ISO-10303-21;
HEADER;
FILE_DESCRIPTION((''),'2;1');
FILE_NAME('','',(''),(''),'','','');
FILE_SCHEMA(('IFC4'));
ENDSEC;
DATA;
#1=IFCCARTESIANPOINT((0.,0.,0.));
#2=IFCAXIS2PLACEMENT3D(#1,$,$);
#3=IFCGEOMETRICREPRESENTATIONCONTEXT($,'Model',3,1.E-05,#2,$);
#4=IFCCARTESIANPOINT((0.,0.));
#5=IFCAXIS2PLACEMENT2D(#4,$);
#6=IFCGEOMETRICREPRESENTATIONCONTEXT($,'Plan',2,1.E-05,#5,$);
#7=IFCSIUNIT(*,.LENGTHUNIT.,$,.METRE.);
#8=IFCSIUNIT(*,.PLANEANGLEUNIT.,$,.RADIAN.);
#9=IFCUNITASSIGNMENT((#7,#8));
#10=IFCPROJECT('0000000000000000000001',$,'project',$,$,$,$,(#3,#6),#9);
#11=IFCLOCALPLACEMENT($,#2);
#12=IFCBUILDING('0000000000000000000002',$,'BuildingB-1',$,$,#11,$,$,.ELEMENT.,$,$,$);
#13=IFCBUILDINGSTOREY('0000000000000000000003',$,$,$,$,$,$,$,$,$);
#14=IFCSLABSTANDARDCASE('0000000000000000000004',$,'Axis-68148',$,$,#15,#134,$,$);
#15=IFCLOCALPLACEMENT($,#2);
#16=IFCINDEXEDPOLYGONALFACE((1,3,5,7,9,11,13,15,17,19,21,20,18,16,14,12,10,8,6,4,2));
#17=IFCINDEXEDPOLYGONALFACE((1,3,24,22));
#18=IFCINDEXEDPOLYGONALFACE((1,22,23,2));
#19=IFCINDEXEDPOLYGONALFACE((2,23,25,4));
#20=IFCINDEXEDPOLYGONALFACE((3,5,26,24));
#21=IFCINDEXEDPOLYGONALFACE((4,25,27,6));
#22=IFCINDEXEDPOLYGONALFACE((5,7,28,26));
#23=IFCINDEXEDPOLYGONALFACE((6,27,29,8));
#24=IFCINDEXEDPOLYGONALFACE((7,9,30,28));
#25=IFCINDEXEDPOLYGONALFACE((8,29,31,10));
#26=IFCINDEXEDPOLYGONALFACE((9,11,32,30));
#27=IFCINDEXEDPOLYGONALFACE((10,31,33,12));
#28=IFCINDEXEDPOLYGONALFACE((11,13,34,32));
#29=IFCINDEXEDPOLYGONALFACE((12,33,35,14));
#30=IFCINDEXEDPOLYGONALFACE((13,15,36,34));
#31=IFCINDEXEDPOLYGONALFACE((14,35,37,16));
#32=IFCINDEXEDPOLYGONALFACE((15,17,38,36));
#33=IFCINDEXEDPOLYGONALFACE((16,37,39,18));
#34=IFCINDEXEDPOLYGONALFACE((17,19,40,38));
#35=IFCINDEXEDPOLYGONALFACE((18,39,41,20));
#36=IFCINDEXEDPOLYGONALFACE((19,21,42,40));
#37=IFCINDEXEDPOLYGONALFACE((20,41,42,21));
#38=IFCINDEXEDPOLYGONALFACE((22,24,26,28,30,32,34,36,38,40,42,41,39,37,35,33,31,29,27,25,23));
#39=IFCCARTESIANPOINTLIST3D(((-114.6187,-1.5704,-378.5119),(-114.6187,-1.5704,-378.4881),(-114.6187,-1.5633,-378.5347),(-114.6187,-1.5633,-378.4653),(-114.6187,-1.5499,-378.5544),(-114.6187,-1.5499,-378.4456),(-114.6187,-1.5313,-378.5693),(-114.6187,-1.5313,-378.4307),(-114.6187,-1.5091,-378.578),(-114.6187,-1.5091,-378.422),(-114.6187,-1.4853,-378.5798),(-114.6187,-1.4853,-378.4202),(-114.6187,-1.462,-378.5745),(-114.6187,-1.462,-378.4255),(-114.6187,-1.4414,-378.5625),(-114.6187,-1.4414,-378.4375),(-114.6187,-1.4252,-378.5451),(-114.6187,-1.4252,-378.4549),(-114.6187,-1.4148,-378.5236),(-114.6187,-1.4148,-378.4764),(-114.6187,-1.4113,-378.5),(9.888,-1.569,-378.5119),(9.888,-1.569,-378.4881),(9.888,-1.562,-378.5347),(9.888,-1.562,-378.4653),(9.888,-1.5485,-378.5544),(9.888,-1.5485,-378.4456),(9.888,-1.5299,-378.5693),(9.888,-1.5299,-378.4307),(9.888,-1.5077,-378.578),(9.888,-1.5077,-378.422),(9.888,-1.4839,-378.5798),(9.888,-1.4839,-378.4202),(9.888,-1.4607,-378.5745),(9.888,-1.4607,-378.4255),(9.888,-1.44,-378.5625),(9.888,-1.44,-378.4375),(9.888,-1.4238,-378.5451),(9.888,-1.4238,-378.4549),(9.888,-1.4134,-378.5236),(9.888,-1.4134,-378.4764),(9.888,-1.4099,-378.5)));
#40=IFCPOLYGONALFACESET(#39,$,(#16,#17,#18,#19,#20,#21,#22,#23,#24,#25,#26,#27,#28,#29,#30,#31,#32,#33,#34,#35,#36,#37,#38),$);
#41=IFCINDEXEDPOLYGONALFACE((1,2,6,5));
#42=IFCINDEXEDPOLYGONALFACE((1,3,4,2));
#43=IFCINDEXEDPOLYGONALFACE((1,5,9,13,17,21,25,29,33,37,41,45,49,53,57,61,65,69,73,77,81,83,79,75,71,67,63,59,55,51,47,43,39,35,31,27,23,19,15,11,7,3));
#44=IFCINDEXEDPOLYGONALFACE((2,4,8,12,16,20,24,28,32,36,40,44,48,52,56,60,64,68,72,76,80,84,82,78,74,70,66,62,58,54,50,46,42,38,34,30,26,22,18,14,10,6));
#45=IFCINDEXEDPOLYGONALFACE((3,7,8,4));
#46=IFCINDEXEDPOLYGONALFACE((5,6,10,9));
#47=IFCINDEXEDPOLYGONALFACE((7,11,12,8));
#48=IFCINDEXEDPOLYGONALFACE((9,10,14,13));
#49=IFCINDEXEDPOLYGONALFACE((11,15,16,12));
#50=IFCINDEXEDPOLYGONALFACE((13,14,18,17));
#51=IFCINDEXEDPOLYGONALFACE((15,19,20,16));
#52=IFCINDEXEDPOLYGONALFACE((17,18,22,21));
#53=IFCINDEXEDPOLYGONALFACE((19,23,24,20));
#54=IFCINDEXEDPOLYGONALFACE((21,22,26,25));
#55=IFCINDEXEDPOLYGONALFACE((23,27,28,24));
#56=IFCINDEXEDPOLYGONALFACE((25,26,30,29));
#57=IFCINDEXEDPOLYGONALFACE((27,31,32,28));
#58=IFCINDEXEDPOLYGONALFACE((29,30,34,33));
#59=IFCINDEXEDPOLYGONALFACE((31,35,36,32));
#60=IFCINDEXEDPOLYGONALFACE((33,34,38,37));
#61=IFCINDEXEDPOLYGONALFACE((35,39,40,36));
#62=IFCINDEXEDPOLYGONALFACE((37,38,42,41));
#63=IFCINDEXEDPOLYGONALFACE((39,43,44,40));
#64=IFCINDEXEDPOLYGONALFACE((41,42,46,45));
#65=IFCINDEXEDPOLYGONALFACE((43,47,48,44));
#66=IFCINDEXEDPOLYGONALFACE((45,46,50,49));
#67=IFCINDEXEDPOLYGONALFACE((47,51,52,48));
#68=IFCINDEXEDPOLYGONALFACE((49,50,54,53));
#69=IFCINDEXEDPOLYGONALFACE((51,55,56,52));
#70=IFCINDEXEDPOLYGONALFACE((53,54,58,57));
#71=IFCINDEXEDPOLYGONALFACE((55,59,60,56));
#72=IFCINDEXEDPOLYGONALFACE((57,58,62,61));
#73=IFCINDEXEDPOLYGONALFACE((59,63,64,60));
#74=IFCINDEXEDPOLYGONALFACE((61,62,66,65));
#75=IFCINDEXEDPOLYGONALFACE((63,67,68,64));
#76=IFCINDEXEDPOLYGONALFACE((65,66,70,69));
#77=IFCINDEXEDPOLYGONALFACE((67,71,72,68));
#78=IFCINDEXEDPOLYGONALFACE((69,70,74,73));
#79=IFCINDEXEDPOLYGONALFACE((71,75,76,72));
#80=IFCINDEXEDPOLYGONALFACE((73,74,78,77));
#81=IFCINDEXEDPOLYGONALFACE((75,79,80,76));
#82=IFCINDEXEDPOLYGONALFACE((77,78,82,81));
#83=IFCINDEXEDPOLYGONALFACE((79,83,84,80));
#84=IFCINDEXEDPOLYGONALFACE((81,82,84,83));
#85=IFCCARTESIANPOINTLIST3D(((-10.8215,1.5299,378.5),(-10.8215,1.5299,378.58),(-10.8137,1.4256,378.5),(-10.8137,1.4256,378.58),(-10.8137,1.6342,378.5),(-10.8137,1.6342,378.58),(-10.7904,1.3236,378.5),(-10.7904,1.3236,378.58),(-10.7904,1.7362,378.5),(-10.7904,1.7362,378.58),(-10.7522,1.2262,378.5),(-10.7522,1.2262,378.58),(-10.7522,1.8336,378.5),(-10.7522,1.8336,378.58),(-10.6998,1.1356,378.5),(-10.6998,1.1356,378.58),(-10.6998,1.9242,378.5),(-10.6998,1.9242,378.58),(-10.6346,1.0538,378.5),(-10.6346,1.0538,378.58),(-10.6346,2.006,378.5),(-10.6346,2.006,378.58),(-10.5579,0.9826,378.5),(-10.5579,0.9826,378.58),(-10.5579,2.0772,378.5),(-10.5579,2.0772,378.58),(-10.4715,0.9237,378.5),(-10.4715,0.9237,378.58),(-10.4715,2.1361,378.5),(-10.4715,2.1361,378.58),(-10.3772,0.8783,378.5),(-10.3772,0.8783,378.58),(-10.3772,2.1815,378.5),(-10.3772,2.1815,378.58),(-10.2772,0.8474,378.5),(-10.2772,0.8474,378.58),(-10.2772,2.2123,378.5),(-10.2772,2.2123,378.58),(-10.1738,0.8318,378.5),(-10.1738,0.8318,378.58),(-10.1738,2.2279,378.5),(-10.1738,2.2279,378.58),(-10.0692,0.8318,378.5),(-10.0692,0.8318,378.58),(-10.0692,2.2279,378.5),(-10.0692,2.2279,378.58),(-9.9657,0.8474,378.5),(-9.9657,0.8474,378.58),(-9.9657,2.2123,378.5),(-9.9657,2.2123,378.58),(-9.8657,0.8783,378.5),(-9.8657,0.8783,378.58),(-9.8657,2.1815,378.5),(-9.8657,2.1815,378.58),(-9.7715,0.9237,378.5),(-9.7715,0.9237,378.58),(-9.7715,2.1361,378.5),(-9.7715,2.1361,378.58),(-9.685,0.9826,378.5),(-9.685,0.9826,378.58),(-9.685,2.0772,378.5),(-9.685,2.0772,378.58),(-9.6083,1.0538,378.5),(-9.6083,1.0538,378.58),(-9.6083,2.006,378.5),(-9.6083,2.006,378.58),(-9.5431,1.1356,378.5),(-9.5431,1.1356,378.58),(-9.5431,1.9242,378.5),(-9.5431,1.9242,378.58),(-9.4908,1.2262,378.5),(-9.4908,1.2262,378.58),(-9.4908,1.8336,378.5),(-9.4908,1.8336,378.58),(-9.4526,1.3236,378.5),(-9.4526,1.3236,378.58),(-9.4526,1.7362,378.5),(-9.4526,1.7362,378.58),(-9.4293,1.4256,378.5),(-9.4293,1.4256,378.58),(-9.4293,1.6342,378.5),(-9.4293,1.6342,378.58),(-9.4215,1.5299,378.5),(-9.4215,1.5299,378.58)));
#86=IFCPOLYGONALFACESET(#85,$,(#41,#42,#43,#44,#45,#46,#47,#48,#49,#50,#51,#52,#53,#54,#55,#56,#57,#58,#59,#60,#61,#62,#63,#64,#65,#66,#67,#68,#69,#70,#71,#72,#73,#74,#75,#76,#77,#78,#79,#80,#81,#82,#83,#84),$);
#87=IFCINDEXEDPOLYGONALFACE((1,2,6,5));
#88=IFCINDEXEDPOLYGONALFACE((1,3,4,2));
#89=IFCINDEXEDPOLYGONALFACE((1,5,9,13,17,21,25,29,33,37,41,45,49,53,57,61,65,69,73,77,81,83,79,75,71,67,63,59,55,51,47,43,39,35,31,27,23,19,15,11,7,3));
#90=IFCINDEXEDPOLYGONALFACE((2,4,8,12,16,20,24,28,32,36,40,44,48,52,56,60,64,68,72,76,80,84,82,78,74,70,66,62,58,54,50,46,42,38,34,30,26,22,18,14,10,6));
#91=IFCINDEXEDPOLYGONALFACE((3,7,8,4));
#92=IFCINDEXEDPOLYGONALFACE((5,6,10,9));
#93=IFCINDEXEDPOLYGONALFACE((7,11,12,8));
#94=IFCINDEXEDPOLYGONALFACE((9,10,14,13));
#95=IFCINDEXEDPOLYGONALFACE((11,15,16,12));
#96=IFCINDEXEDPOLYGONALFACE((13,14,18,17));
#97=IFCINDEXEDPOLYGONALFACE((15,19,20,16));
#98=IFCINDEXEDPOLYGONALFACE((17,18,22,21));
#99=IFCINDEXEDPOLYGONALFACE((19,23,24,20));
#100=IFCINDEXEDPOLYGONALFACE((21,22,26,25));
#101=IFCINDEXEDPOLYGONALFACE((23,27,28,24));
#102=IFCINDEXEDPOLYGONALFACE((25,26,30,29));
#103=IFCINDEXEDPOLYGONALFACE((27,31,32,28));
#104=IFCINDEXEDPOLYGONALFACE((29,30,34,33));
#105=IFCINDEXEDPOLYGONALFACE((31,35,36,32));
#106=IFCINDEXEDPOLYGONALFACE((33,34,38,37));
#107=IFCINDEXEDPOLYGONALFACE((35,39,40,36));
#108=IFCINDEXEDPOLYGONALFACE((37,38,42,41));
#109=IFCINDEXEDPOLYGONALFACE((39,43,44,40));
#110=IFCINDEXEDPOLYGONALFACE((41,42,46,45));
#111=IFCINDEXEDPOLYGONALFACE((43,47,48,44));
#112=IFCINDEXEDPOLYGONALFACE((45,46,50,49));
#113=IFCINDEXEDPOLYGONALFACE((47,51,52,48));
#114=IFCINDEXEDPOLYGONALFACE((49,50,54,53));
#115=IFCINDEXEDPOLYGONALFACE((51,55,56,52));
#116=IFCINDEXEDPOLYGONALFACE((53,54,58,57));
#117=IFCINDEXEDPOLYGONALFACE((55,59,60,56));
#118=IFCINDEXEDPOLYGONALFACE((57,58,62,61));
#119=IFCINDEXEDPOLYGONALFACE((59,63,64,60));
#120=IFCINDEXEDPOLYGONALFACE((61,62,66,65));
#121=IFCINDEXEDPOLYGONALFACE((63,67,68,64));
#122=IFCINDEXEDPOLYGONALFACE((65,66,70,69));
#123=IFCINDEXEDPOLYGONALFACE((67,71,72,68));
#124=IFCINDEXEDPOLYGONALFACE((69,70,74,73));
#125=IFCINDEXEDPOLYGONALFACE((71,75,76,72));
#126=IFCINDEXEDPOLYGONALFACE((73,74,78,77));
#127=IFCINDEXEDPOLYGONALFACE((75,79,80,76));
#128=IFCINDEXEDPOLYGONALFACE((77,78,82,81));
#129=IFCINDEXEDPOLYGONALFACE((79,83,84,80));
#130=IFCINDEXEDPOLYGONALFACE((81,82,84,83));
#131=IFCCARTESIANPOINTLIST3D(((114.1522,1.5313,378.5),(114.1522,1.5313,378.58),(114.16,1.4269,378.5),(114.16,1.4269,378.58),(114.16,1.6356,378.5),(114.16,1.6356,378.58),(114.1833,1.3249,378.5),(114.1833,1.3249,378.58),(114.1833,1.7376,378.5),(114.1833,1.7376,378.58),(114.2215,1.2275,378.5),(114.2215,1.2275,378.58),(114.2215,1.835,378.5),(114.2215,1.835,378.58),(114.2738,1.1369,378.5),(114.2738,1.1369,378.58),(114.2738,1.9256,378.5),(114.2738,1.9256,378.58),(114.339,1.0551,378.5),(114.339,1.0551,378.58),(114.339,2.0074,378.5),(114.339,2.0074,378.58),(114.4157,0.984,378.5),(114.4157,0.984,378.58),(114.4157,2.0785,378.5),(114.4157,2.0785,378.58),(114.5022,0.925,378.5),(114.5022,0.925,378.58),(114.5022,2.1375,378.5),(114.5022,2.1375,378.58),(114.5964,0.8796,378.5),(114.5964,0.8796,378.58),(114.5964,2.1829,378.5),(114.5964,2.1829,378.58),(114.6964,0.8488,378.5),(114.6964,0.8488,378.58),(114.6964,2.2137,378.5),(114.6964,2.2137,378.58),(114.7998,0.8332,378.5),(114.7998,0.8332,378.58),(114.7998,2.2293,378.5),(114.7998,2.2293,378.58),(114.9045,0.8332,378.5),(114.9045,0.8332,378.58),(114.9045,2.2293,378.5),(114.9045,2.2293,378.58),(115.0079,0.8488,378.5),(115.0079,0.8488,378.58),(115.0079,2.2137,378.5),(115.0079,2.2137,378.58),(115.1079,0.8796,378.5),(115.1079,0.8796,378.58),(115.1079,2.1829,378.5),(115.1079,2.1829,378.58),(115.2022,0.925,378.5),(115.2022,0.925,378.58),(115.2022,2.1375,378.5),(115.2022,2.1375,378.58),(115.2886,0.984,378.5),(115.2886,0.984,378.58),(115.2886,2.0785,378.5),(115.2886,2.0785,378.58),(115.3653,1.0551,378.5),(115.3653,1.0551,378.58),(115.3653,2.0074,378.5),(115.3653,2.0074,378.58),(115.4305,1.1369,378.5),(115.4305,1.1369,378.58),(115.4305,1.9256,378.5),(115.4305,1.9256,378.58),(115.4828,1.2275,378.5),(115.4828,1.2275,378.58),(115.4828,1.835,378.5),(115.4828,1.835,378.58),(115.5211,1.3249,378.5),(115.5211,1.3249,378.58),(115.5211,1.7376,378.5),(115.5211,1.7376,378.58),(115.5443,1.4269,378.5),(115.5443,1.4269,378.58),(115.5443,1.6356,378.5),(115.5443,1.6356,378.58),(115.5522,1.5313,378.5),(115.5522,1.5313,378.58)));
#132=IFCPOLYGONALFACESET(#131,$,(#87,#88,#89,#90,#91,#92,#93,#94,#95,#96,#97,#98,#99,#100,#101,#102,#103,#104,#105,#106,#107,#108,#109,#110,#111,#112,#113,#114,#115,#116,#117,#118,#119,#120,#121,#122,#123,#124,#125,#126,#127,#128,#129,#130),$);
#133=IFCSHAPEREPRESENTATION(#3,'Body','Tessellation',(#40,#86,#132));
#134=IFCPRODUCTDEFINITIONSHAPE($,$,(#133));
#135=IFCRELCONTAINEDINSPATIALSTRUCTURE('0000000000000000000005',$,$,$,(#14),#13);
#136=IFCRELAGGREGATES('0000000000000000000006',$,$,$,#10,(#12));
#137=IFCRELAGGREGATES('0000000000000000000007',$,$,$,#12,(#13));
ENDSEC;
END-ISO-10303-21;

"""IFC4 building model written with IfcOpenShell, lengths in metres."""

from ifc_helpers import new_model, entity, si_unit, frame, origin, origin_2d, place, context, project, spatial, circle, extrude, element, save


model = new_model("IFC4")

# Units and contexts
model_context = context("Model", 3, precision=1e-05, world=origin())
plan_context = context("Plan", 2, precision=1e-05, world=origin_2d())
ifc_project = project(units=[si_unit("LENGTHUNIT", "METRE"), si_unit("PLANEANGLEUNIT", "RADIAN")], contexts=[model_context, plan_context])

# Building, storey
building_placement = place(None, origin())
building = spatial("IfcBuilding", under=ifc_project, at=building_placement, Name="BuildingB-1", CompositionType="ELEMENT")
storey = spatial("IfcBuildingStorey", under=building)

# Slab
element("IfcSlabStandardCase", 1, inside=storey, Name="Axis-68148", context=model_context, shape_type="AdvancedSweptSolid", body=[
    entity("IfcSurfaceCurveSweptAreaSolid", entity("IfcCircleProfileDef", "AREA", None, None, 0.08), None, entity("IfcPolyline", [entity("IfcCartesianPoint", [-9.888, 1.4899, 378.5]), entity("IfcCartesianPoint", [114.6187, 1.4913, 378.5])]), None, None, entity("IfcPlane", entity("IfcAxis2Placement3D", entity("IfcCartesianPoint", [-9.888, 1.4899, 378.5]), entity("IfcDirection", [0.0, 0.0, 1.0]), entity("IfcDirection", [1.0, 0.0, 0.0])))),
    extrude(circle(Radius=0.7), frame((-10.1215, 1.5299, 378.5)), (0.0, 0.0, 1.0), 0.08),
    extrude(circle(Radius=0.7), frame((114.8522, 1.5313, 378.5)), (0.0, 0.0, 1.0), 0.08),
])

save(model, "model.ifc")
